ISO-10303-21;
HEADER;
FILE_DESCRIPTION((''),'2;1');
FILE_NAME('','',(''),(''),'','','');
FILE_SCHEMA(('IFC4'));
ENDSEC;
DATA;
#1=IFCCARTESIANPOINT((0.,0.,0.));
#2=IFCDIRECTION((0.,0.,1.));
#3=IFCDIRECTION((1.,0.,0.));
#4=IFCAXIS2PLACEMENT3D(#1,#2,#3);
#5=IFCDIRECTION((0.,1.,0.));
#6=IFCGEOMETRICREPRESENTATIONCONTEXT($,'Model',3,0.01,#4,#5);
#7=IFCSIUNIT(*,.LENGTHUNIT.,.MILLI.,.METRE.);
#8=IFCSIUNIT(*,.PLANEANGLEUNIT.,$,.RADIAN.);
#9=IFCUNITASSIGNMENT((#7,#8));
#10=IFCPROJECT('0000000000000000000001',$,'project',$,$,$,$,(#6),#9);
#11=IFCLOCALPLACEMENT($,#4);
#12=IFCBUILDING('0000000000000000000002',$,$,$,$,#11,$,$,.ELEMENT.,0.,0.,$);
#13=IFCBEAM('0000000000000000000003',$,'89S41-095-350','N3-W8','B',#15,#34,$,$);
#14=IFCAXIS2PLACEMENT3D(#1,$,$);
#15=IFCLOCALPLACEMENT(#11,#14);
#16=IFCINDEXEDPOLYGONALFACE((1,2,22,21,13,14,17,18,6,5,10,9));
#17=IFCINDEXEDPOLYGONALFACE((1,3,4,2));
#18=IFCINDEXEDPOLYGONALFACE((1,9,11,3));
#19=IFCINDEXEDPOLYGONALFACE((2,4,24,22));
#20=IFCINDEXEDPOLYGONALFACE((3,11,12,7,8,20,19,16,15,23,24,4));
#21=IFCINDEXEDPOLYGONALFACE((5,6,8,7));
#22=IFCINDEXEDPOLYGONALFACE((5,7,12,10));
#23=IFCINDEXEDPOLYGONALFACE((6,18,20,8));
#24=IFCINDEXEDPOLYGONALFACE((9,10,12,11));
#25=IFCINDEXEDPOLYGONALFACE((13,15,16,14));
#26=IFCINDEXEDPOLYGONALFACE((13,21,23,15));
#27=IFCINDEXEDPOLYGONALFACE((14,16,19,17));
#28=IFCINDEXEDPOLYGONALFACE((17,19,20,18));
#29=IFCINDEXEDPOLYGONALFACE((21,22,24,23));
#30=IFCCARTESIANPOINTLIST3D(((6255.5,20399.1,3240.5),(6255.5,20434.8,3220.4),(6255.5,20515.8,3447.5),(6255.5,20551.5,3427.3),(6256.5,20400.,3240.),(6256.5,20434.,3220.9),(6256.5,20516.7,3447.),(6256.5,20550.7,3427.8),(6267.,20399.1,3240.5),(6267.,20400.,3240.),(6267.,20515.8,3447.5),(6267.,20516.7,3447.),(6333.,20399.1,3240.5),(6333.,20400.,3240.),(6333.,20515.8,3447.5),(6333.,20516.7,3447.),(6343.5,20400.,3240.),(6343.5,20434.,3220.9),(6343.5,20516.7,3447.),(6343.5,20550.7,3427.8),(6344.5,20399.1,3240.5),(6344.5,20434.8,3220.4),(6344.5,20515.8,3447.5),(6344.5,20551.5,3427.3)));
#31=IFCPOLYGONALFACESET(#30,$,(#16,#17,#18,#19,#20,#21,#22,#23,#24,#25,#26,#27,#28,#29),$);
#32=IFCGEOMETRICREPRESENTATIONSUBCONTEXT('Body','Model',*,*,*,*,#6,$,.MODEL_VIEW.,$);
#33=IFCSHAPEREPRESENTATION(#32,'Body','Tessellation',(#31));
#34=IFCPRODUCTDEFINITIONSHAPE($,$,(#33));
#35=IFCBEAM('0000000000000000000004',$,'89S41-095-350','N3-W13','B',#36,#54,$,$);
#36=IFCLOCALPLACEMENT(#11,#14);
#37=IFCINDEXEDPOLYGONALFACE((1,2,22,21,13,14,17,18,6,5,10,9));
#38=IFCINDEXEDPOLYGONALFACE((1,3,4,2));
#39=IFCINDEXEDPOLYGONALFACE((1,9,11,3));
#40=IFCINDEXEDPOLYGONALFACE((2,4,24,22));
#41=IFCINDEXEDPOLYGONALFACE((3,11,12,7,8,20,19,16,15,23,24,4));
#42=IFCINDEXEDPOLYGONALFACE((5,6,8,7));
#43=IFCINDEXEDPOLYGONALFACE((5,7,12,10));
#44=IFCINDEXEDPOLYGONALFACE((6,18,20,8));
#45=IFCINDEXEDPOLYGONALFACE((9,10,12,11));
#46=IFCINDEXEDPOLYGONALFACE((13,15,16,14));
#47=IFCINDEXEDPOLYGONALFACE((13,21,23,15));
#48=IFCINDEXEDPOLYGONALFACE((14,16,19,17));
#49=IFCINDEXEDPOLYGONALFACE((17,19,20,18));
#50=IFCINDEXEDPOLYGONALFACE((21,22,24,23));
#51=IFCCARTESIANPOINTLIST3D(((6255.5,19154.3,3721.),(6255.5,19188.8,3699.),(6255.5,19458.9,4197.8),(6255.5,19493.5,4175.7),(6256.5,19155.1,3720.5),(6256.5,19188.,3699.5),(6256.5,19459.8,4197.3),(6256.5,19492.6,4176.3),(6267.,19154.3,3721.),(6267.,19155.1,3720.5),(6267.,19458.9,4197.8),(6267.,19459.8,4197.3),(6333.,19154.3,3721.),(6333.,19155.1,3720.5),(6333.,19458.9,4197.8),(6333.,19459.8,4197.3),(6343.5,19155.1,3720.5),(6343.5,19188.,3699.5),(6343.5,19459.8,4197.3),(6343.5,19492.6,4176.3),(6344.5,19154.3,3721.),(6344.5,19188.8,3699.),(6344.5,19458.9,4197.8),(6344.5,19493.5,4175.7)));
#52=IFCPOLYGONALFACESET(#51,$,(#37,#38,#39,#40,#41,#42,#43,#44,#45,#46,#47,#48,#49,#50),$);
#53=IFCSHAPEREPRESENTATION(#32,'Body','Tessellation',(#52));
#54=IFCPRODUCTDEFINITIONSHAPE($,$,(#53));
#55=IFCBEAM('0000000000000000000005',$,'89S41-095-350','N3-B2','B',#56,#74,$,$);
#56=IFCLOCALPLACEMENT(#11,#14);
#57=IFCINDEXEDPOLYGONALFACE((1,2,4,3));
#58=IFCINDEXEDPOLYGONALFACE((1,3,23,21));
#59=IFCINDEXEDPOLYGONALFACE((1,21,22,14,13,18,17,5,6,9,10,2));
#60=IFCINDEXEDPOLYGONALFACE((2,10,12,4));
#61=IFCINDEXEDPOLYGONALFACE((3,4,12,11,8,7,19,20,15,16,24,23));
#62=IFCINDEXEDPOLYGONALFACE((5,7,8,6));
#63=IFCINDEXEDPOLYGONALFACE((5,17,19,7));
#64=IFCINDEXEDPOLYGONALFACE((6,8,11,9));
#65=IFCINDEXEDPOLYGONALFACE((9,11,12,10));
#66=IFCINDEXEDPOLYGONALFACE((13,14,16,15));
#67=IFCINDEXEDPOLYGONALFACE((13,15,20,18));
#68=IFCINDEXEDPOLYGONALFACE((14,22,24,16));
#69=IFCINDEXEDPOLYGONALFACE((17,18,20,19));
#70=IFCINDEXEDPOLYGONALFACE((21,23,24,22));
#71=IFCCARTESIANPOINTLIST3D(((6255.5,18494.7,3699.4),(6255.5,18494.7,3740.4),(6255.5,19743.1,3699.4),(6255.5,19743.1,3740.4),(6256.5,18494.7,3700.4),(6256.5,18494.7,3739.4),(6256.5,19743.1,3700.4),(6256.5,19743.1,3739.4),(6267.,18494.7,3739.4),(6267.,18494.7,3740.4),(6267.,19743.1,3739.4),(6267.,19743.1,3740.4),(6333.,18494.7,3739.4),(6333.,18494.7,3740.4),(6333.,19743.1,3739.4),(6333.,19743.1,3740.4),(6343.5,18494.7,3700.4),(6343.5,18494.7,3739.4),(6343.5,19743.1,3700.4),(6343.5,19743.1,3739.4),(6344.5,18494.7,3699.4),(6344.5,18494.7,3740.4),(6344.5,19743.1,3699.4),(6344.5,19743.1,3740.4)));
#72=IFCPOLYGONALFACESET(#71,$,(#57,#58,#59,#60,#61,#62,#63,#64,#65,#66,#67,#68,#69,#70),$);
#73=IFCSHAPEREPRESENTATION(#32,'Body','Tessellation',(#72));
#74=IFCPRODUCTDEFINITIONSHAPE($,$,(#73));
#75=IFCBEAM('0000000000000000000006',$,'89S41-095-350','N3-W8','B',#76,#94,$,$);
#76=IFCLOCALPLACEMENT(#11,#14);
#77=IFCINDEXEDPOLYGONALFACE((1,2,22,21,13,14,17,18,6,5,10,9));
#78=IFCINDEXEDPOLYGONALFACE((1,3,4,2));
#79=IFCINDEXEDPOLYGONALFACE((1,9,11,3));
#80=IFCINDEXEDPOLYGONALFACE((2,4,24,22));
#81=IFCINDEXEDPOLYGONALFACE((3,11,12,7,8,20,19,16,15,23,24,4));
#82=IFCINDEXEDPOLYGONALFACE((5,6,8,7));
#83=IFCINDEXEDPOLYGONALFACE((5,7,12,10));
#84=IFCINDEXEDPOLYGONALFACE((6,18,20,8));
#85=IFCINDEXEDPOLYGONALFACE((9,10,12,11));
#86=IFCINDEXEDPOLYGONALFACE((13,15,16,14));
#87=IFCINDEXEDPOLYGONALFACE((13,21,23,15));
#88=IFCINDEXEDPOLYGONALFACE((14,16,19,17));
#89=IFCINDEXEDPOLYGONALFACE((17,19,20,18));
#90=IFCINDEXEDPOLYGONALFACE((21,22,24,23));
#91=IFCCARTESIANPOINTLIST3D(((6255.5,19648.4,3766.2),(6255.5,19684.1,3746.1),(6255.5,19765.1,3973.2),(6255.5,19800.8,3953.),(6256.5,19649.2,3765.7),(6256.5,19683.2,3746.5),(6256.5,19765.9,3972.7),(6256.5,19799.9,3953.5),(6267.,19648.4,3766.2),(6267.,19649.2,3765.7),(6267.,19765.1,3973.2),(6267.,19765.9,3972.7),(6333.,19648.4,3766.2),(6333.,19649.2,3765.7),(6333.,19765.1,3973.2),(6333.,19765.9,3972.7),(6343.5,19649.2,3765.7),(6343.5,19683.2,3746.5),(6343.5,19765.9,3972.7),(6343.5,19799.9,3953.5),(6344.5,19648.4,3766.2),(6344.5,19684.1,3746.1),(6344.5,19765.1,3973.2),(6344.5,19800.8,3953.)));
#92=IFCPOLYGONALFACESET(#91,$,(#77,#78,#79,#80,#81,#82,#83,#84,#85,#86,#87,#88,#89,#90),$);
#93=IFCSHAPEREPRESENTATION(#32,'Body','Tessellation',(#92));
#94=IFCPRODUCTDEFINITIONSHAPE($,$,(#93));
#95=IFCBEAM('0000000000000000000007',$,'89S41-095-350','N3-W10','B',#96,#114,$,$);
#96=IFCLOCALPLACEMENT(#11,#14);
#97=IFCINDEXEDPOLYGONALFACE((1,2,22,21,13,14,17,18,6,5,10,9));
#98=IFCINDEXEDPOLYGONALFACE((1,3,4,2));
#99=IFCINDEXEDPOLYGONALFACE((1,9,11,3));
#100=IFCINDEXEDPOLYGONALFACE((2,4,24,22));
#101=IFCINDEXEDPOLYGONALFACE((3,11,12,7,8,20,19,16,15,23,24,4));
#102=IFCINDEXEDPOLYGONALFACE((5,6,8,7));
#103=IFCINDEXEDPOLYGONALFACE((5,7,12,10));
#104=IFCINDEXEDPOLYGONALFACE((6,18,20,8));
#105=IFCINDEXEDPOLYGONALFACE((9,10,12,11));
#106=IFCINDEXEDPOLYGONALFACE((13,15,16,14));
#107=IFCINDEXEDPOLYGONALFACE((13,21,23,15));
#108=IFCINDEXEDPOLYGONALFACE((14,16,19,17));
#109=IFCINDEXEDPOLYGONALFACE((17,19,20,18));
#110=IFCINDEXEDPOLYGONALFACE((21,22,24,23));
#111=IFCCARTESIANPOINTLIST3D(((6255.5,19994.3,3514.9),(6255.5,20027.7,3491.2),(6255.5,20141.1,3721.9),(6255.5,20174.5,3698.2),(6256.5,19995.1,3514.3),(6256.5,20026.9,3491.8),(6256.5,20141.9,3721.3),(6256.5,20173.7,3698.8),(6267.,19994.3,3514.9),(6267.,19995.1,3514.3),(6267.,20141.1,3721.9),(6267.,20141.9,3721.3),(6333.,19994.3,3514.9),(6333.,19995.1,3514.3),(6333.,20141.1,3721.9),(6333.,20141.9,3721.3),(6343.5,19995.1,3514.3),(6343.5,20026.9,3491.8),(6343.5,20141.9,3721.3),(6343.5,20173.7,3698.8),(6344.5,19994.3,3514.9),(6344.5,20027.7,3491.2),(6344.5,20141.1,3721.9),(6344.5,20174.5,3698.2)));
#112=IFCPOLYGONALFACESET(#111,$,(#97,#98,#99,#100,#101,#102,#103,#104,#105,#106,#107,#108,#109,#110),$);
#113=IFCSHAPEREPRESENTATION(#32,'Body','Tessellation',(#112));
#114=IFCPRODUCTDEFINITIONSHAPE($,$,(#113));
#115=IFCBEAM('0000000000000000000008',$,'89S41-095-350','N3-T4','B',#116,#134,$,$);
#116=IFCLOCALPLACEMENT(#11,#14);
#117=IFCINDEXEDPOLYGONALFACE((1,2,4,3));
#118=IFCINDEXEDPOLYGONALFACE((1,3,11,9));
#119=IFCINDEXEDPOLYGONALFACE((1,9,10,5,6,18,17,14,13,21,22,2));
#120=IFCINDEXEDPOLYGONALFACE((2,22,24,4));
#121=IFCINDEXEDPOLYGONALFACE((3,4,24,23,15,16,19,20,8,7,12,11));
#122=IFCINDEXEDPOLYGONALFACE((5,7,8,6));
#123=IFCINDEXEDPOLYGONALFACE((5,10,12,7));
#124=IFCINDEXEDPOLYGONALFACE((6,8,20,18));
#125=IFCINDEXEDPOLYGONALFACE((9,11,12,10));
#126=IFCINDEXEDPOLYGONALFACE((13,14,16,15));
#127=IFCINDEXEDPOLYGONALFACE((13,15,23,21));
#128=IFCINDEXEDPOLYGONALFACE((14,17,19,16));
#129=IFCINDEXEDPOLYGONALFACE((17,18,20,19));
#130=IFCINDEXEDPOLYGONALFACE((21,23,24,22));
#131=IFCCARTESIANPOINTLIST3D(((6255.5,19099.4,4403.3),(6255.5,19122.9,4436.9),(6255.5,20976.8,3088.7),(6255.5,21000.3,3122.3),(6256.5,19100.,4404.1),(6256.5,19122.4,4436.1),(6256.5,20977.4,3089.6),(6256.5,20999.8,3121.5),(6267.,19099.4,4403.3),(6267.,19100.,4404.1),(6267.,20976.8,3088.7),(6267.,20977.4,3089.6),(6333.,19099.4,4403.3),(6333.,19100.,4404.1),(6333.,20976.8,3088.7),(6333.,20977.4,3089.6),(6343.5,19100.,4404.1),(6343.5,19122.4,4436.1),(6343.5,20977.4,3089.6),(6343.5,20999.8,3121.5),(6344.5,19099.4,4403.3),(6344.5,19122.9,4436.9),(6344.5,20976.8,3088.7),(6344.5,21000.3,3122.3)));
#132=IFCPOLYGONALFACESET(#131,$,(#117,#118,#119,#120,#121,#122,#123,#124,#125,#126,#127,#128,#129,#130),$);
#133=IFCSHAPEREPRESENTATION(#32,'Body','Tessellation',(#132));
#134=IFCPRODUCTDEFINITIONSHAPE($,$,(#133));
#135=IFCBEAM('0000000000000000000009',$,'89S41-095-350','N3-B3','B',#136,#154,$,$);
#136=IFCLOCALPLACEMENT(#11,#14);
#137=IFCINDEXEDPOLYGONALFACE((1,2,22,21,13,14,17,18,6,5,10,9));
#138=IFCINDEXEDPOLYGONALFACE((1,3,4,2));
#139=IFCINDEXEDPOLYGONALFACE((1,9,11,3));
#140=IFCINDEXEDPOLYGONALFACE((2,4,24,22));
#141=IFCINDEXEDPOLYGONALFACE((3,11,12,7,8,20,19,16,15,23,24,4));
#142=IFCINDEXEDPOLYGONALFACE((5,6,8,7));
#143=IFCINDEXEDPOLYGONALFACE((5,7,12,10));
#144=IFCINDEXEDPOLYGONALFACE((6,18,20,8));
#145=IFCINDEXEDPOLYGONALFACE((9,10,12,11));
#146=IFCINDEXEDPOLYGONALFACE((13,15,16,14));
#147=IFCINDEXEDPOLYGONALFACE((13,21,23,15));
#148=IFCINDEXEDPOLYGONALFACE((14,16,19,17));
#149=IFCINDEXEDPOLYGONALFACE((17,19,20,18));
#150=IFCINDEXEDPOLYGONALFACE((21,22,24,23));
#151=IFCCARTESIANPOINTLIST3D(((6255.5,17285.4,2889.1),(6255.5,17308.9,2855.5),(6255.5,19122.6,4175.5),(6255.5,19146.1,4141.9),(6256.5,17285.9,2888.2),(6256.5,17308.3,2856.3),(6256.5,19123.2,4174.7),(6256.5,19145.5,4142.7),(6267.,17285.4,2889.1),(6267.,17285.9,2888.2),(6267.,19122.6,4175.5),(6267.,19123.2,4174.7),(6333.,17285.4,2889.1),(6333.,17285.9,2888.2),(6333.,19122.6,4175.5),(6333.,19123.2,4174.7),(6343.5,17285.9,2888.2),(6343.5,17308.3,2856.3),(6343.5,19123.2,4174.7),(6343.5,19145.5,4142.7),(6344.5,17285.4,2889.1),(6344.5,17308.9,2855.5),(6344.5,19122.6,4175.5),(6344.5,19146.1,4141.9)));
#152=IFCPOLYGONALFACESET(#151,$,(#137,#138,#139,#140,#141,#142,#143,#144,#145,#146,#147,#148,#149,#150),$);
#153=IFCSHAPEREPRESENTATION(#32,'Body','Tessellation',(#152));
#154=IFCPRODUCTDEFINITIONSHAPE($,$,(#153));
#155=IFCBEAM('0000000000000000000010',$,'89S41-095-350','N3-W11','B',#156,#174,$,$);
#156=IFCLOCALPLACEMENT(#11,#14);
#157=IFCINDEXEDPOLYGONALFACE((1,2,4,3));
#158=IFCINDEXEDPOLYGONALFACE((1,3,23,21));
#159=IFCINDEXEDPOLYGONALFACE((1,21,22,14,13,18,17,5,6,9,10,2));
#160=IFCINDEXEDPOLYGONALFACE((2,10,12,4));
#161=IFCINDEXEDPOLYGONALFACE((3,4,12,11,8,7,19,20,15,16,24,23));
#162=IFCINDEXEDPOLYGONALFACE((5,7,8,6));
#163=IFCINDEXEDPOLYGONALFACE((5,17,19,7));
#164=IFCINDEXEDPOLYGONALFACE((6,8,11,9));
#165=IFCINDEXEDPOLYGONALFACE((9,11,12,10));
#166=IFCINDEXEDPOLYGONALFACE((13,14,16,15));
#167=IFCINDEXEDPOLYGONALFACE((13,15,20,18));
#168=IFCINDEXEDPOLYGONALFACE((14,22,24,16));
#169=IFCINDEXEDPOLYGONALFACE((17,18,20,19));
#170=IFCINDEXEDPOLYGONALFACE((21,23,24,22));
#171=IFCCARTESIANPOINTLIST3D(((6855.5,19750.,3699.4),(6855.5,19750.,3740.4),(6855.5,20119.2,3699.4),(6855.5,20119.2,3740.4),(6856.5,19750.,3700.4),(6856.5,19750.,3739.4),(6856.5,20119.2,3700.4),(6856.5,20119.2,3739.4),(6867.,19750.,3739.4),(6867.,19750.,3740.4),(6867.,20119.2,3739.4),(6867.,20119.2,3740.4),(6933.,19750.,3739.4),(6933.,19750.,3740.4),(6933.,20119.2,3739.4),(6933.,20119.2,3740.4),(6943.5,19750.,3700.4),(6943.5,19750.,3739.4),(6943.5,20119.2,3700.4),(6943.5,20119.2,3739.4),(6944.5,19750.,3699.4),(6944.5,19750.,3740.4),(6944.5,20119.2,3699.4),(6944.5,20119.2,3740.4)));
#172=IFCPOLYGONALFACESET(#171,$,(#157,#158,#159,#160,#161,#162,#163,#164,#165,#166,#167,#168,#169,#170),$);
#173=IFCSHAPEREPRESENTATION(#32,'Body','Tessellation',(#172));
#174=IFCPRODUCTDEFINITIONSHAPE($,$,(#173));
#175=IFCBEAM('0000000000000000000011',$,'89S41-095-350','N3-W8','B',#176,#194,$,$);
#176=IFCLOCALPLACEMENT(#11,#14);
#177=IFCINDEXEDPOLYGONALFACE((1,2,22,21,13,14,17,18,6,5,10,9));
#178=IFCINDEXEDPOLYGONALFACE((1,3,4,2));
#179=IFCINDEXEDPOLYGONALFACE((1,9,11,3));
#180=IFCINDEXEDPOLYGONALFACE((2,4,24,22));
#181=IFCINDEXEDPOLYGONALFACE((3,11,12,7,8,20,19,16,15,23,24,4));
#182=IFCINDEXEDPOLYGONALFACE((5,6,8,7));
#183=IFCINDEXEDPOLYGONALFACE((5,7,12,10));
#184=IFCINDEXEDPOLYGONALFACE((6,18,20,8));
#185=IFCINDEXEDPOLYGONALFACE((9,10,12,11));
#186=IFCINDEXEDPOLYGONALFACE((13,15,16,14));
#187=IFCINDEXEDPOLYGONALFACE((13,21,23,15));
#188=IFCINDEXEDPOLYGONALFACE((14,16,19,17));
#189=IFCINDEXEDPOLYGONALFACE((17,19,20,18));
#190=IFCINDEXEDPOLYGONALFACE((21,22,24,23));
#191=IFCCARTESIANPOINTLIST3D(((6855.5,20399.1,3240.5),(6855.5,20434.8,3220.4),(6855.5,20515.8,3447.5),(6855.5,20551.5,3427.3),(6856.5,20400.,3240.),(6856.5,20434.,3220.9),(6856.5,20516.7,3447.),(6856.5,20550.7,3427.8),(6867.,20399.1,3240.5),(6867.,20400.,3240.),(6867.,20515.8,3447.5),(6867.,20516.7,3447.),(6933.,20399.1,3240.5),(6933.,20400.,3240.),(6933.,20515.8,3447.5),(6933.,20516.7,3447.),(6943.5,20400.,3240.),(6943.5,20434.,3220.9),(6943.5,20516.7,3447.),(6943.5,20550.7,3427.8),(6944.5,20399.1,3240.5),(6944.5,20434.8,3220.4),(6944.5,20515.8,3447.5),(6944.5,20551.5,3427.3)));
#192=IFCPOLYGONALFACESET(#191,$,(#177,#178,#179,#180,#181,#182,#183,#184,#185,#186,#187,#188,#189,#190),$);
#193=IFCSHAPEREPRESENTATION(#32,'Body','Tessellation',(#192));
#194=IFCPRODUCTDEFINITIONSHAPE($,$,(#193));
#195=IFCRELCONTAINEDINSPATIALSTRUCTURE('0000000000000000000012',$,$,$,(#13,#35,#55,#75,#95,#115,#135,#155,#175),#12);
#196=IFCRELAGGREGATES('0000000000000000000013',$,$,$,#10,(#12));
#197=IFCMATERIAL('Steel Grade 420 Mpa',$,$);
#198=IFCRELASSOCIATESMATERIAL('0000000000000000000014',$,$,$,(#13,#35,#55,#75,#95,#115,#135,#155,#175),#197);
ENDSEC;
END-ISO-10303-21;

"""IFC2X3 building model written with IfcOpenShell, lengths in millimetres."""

from ifc_helpers import new_model, si_unit, direction, frame, origin, origin_with_axes, origin_2d_with_axis, place, context, subcontext, project, spatial, c_section, extrude, source, transform, mapped, material, element, save


model = new_model("IFC2X3")

# Units and contexts
model_context = context("Model", 3, precision=0.01, world=origin_with_axes(), true_north=direction((0.0, 1.0, 0.0)))
body_context = subcontext(model_context, "Body", "Model", "MODEL_VIEW")
ifc_project = project(units=[si_unit("LENGTHUNIT", "METRE", prefix="MILLI"), si_unit("PLANEANGLEUNIT", "RADIAN")], contexts=[model_context])

# Building
building_placement = place(None, origin_with_axes())
building = spatial("IfcBuilding", under=ifc_project, at=building_placement, CompositionType="ELEMENT", ElevationOfRefHeight=0.0, ElevationOfTerrain=0.0)

# Shared definitions
ifc_material = material(Name="Steel Grade 420 Mpa")

# Beams
shared_shape_1 = source(origin(), body_context, "Body", "SweptSolid", [
    extrude(c_section(Depth=89.0, Width=41.0, WallThickness=1.0, Girth=11.5, at=origin_2d_with_axis()), origin_with_axes(), (0.0, 0.0, 1.0), 237.6),
])
beam_1_placement = place(None, frame((6300.0, 20533.7, 3437.4), z_axis=(0.0, -0.491169, -0.871064), x_axis=(0.0, -0.871064, 0.491169)))
element("IfcBeam", 1, at=beam_1_placement, inside=building, material=ifc_material, Name="89S41-095-350", Description="N3-W8", ObjectType="B", context=body_context, shape_type="MappedRepresentation", body=[
    mapped(shared_shape_1, transform((0.0, 0.0, 0.0), scale=1.0)),
])
shared_shape_2 = source(origin(), body_context, "Body", "SweptSolid", [
    extrude(c_section(Depth=89.0, Width=41.0, WallThickness=1.0, Girth=11.5, at=origin_2d_with_axis()), origin_with_axes(), (0.0, 0.0, 1.0), 565.8),
])
beam_2_placement = place(None, frame((6300.0, 19476.2, 4186.8), z_axis=(0.0, -0.538498, -0.842627), x_axis=(0.0, -0.842627, 0.538498)))
element("IfcBeam", 2, at=beam_2_placement, inside=building, material=ifc_material, Name="89S41-095-350", Description="N3-W13", ObjectType="B", context=body_context, shape_type="MappedRepresentation", body=[
    mapped(shared_shape_2, transform((0.0, 0.0, 0.0), scale=1.0)),
])
shared_shape_3 = source(origin(), body_context, "Body", "SweptSolid", [
    extrude(c_section(Depth=89.0, Width=41.0, WallThickness=1.0, Girth=11.5, at=origin_2d_with_axis()), origin_with_axes(), (0.0, 0.0, 1.0), 1248.4),
])
beam_3_placement = place(None, frame((6300.0, 19743.1, 3719.9), z_axis=(0.0, -1.0, 0.0), x_axis=(0.0, 0.0, 1.0)))
element("IfcBeam", 3, at=beam_3_placement, inside=building, material=ifc_material, Name="89S41-095-350", Description="N3-B2", ObjectType="B", context=body_context, shape_type="MappedRepresentation", body=[
    mapped(shared_shape_3, transform((0.0, 0.0, 0.0), scale=1.0)),
])
shared_shape_4 = source(origin(), body_context, "Body", "SweptSolid", [
    extrude(c_section(Depth=89.0, Width=41.0, WallThickness=1.0, Girth=11.5, at=origin_2d_with_axis()), origin_with_axes(), (0.0, 0.0, 1.0), 237.6),
])
beam_4_placement = place(None, frame((6300.0, 19782.9, 3963.1), z_axis=(0.0, -0.491169, -0.871064), x_axis=(0.0, -0.871064, 0.491169)))
element("IfcBeam", 4, at=beam_4_placement, inside=building, material=ifc_material, Name="89S41-095-350", Description="N3-W8", ObjectType="B", context=body_context, shape_type="MappedRepresentation", body=[
    mapped(shared_shape_4, transform((0.0, 0.0, 0.0), scale=1.0)),
])
shared_shape_5 = source(origin(), body_context, "Body", "SweptSolid", [
    extrude(c_section(Depth=89.0, Width=41.0, WallThickness=1.0, Girth=11.5, at=origin_2d_with_axis()), origin_with_axes(), (0.0, 0.0, 1.0), 253.8),
])
beam_5_placement = place(None, frame((6300.0, 20157.8, 3710.0), z_axis=(0.0, -0.578484, -0.815694), x_axis=(0.0, -0.815694, 0.578484)))
element("IfcBeam", 5, at=beam_5_placement, inside=building, material=ifc_material, Name="89S41-095-350", Description="N3-W10", ObjectType="B", context=body_context, shape_type="MappedRepresentation", body=[
    mapped(shared_shape_5, transform((0.0, 0.0, 0.0), scale=1.0)),
])
shared_shape_6 = source(origin(), body_context, "Body", "SweptSolid", [
    extrude(c_section(Depth=89.0, Width=41.0, WallThickness=1.0, Girth=11.5, at=origin_2d_with_axis()), origin_with_axes(), (0.0, 0.0, 1.0), 2291.9),
])
beam_6_placement = place(None, frame((6300.0, 19111.2, 4420.1), z_axis=(0.0, 0.819152, -0.573576), x_axis=(0.0, -0.573576, -0.819152)))
element("IfcBeam", 6, at=beam_6_placement, inside=building, material=ifc_material, Name="89S41-095-350", Description="N3-T4", ObjectType="B", context=body_context, shape_type="MappedRepresentation", body=[
    mapped(shared_shape_6, transform((0.0, 0.0, 0.0), scale=1.0)),
])
shared_shape_7 = source(origin(), body_context, "Body", "SweptSolid", [
    extrude(c_section(Depth=89.0, Width=41.0, WallThickness=1.0, Girth=11.5, at=origin_2d_with_axis()), origin_with_axes(), (0.0, 0.0, 1.0), 2242.8),
])
beam_7_placement = place(None, frame((6300.0, 19134.3, 4158.7), z_axis=(0.0, -0.819152, -0.573576), x_axis=(0.0, -0.573576, 0.819152)))
element("IfcBeam", 7, at=beam_7_placement, inside=building, material=ifc_material, Name="89S41-095-350", Description="N3-B3", ObjectType="B", context=body_context, shape_type="MappedRepresentation", body=[
    mapped(shared_shape_7, transform((0.0, 0.0, 0.0), scale=1.0)),
])
shared_shape_8 = source(origin(), body_context, "Body", "SweptSolid", [
    extrude(c_section(Depth=89.0, Width=41.0, WallThickness=1.0, Girth=11.5, at=origin_2d_with_axis()), origin_with_axes(), (0.0, 0.0, 1.0), 369.2),
])
beam_8_placement = place(None, frame((6900.0, 20119.2, 3719.9), z_axis=(0.0, -1.0, 0.0), x_axis=(0.0, 0.0, 1.0)))
element("IfcBeam", 8, at=beam_8_placement, inside=building, material=ifc_material, Name="89S41-095-350", Description="N3-W11", ObjectType="B", context=body_context, shape_type="MappedRepresentation", body=[
    mapped(shared_shape_8, transform((0.0, 0.0, 0.0), scale=1.0)),
])
shared_shape_9 = source(origin(), body_context, "Body", "SweptSolid", [
    extrude(c_section(Depth=89.0, Width=41.0, WallThickness=1.0, Girth=11.5, at=origin_2d_with_axis()), origin_with_axes(), (0.0, 0.0, 1.0), 237.6),
])
beam_9_placement = place(None, frame((6900.0, 20533.7, 3437.4), z_axis=(0.0, -0.491169, -0.871064), x_axis=(0.0, -0.871064, 0.491169)))
element("IfcBeam", 9, at=beam_9_placement, inside=building, material=ifc_material, Name="89S41-095-350", Description="N3-W8", ObjectType="B", context=body_context, shape_type="MappedRepresentation", body=[
    mapped(shared_shape_9, transform((0.0, 0.0, 0.0), scale=1.0)),
])

save(model, "model.ifc")
